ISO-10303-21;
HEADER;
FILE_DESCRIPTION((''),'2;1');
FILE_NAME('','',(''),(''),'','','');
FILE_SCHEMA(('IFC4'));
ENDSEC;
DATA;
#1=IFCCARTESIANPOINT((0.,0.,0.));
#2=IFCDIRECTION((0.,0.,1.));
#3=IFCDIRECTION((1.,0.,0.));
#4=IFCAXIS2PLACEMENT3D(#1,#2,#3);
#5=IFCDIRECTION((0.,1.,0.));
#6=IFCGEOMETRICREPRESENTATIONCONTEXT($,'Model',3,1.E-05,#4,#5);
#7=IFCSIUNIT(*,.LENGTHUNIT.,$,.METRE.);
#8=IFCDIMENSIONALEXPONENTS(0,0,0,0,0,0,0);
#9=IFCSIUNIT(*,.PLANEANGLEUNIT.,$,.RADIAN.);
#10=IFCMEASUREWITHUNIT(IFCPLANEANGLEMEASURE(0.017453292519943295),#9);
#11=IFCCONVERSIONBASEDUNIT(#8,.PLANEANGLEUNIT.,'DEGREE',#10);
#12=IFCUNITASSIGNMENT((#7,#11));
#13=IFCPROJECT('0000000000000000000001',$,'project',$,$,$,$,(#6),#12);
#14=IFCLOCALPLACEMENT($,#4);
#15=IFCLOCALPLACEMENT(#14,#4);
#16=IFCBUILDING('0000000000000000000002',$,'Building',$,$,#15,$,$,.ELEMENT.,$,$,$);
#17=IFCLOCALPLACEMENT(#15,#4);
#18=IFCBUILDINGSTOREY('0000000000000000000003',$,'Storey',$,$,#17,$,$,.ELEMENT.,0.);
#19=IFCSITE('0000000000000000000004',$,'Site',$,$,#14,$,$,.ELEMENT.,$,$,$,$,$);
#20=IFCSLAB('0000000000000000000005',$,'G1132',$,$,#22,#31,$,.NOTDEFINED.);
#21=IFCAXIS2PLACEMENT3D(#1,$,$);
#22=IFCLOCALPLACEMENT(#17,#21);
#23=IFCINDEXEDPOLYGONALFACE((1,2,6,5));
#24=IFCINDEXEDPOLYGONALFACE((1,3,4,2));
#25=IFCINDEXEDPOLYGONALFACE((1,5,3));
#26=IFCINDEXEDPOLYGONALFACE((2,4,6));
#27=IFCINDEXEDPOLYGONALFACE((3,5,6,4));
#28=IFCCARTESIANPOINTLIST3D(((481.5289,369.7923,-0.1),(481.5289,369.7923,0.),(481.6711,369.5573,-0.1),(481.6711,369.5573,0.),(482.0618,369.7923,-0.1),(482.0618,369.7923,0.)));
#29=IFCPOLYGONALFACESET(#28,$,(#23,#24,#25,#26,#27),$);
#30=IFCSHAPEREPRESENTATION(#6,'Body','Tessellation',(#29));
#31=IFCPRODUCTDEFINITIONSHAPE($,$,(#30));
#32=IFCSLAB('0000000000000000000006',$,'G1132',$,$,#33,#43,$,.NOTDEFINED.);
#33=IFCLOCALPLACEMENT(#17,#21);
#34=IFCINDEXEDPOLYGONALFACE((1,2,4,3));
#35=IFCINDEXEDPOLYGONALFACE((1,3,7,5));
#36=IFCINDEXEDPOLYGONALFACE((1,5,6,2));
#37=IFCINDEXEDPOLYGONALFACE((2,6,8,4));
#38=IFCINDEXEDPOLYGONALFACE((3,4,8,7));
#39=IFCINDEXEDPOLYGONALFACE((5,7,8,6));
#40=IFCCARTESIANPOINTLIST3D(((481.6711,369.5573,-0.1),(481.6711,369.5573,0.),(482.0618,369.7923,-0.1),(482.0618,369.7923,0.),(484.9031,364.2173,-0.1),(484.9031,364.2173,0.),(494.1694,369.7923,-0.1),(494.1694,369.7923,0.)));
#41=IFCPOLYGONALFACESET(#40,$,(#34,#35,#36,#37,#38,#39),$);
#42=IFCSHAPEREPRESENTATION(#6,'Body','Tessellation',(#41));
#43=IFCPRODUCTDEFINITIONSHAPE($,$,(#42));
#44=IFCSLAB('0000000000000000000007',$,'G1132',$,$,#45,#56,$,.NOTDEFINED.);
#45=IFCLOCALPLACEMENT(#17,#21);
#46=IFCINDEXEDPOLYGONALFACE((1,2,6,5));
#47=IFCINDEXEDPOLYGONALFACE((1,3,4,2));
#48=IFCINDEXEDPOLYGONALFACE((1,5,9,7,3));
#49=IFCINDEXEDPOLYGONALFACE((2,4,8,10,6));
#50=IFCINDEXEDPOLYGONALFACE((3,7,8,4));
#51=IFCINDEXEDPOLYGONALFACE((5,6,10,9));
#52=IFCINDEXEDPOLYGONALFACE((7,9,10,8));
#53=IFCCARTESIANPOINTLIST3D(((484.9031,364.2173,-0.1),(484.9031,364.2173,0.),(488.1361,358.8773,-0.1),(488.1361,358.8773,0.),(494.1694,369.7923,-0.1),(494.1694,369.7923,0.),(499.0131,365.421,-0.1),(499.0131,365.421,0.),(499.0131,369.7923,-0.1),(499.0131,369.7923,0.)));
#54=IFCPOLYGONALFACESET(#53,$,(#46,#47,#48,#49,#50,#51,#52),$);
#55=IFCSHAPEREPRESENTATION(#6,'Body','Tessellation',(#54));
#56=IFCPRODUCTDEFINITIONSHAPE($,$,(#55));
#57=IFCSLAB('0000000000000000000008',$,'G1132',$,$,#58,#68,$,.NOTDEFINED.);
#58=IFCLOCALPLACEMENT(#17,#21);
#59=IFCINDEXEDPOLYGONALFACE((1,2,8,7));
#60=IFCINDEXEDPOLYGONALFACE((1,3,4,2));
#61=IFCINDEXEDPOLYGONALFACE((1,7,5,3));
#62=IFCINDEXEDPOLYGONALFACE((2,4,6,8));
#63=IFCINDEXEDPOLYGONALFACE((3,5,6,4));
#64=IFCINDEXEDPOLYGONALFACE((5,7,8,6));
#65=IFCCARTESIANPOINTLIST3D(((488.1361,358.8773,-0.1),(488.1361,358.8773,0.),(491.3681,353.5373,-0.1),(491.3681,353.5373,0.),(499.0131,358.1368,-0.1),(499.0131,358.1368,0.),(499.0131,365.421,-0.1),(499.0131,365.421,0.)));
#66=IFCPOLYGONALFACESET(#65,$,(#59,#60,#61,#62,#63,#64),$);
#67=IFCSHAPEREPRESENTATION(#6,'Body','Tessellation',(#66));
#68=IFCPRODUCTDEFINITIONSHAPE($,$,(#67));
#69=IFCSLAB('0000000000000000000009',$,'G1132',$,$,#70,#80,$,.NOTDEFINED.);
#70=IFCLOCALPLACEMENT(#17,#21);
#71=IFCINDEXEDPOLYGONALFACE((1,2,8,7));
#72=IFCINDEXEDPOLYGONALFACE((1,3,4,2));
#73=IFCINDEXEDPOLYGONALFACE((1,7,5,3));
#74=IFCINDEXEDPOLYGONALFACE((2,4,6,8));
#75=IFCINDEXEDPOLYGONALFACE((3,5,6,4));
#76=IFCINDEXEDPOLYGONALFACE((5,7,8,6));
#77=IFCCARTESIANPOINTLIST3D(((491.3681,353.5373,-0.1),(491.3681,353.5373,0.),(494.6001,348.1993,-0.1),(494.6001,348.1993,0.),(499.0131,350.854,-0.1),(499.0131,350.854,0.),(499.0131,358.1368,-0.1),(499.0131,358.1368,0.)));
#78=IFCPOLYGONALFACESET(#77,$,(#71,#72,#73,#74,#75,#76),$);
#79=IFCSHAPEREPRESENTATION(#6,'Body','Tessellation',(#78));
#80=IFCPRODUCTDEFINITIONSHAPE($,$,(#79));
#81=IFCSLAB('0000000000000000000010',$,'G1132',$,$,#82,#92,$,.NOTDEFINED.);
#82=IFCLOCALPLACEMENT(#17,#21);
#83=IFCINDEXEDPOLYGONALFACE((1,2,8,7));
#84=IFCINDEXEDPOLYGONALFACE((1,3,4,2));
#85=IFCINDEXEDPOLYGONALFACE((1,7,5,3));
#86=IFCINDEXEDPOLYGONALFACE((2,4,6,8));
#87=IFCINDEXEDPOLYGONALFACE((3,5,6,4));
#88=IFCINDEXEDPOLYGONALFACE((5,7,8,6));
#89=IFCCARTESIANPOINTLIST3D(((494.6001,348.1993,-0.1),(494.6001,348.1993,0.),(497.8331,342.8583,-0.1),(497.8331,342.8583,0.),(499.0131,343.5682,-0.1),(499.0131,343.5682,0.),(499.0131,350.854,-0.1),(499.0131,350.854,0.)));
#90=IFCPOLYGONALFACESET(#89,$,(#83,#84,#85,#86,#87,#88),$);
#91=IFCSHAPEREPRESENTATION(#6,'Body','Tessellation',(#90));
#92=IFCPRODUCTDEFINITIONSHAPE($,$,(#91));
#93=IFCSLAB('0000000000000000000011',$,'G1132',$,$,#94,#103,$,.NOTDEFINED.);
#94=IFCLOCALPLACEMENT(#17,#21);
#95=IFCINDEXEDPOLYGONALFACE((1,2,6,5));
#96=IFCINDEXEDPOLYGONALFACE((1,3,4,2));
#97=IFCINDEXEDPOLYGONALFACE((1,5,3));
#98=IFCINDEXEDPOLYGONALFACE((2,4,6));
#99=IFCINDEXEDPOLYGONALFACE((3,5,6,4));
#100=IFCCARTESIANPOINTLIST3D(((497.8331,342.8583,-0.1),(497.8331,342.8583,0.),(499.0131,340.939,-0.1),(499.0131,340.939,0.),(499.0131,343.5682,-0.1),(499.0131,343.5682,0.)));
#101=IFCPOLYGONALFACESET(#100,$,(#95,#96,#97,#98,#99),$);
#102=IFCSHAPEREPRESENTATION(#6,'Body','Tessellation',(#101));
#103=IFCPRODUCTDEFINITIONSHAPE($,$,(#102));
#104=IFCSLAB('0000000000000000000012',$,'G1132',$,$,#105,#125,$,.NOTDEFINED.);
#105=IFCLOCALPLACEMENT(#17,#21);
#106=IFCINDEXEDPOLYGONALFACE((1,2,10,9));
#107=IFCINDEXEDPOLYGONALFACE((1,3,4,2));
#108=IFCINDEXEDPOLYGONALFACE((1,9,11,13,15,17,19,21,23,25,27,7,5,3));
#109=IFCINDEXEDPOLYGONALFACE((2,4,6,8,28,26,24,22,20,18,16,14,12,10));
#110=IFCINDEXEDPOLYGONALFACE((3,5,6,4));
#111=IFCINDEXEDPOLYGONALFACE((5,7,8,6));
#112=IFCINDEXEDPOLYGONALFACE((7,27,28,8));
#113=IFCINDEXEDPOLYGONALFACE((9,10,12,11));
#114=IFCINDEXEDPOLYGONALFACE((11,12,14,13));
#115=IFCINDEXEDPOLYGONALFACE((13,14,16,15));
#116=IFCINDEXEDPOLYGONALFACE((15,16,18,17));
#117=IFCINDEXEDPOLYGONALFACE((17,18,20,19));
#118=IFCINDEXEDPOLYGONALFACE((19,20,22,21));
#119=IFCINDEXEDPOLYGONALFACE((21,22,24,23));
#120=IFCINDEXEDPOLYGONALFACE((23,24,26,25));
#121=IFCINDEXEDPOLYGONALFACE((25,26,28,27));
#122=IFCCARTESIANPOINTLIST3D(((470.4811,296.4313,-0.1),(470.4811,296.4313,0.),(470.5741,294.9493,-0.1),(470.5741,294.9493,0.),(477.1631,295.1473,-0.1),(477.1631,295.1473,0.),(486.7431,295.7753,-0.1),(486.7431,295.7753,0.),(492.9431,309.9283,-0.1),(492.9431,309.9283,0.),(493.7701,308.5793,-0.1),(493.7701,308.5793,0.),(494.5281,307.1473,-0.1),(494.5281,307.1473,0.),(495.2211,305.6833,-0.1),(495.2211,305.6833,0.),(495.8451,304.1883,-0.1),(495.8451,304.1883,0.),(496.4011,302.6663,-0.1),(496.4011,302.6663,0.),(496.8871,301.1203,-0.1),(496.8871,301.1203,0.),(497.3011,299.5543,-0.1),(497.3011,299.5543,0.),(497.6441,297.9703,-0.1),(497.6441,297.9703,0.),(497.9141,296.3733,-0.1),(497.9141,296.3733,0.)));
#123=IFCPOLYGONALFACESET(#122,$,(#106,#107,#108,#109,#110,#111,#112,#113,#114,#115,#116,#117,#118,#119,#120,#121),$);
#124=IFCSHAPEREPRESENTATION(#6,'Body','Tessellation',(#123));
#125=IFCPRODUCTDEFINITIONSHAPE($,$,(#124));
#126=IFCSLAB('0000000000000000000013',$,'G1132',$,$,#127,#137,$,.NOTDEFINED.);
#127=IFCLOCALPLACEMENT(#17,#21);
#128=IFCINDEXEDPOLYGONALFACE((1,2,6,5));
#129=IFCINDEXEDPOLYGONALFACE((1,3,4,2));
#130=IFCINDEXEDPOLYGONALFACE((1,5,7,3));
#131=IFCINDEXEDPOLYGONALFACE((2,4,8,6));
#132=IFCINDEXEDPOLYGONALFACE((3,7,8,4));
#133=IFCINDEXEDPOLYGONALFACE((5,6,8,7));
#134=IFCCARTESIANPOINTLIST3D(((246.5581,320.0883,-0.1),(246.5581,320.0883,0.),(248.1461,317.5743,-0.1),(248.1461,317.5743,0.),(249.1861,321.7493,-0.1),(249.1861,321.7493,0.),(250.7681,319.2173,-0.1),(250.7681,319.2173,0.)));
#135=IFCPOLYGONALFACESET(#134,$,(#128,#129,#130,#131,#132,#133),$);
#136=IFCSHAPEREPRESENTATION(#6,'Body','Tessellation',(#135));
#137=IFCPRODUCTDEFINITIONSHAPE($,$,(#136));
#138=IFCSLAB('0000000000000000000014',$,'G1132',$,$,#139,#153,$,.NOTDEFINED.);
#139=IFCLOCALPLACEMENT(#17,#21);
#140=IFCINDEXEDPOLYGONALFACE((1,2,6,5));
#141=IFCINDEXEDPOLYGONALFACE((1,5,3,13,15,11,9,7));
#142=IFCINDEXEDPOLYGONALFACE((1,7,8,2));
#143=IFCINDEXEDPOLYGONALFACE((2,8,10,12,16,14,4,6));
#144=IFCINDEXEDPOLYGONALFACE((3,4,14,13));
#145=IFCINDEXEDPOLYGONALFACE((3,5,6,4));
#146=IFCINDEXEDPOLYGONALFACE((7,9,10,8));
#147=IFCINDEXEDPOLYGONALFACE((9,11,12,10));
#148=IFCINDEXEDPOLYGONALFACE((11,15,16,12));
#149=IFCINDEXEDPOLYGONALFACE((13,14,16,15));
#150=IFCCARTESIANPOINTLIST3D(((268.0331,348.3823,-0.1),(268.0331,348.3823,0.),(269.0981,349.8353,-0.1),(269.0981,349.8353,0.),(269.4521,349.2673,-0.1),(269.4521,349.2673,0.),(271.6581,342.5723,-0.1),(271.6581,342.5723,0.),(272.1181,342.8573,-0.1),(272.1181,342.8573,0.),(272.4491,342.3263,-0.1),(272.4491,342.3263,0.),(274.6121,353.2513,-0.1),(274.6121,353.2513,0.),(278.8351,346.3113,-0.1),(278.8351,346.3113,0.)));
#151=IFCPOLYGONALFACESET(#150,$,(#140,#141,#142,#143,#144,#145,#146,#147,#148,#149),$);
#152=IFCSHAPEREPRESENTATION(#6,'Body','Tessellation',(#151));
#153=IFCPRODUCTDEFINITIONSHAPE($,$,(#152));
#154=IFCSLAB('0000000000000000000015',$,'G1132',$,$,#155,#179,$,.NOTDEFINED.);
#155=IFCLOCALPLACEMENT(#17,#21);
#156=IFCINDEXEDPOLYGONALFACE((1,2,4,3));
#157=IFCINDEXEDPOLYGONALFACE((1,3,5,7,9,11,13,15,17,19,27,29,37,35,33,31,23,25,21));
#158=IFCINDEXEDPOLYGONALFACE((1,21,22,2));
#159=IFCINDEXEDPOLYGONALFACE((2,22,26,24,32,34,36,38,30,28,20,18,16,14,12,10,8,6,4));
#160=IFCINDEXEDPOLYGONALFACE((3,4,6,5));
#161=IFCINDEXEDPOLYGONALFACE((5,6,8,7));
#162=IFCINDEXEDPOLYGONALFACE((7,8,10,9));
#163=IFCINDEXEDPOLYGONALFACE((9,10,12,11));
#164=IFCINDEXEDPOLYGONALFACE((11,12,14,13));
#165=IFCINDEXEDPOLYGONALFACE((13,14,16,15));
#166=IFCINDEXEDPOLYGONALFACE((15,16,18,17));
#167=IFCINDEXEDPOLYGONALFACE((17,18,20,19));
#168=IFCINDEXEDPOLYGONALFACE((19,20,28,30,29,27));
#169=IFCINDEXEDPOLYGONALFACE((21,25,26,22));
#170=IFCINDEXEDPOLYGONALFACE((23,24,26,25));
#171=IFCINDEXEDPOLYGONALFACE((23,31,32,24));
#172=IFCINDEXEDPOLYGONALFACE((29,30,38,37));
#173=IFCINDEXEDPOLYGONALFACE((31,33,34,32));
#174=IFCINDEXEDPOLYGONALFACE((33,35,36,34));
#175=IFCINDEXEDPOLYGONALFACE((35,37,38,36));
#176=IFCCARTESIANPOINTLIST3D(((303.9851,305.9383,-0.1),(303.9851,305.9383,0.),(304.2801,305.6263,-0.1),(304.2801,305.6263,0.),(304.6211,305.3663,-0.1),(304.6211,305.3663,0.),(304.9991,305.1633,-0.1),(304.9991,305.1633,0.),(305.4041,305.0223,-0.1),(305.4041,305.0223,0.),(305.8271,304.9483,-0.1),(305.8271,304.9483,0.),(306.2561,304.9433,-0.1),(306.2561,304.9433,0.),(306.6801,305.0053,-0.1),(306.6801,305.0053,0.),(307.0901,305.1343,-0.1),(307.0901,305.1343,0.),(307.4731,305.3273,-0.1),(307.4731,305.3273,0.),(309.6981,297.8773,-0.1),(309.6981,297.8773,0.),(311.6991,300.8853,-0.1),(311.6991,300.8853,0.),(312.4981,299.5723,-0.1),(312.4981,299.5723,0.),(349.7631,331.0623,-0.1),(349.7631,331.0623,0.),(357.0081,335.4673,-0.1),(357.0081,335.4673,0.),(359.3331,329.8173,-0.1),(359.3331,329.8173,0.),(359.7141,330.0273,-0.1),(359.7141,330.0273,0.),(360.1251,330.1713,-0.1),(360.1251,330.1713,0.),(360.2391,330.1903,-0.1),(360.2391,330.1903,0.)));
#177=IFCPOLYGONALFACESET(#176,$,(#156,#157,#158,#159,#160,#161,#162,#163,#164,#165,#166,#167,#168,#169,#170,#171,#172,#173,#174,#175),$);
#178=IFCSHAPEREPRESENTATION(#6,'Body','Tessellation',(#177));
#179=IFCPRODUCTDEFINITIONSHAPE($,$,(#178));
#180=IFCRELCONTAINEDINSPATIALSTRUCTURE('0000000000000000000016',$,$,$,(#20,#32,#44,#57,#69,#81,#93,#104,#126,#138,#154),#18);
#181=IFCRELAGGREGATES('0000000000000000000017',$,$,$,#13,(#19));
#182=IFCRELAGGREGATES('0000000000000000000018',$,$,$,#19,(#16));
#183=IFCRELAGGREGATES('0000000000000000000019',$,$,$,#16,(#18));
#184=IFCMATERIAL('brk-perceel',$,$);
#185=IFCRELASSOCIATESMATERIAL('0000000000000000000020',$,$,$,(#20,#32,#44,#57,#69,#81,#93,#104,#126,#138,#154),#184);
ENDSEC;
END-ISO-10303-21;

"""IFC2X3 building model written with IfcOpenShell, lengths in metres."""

from ifc_helpers import new_model, entity, si_unit, converted_unit, direction, frame, origin_with_axes, place, context, project, spatial, polyline, outline, extrude, material, element, save


model = new_model("IFC2X3")

# Units and contexts
model_context = context("Model", 3, precision=1e-05, world=origin_with_axes(), true_north=direction((0.0, 1.0, 0.0)))
ifc_project = project(units=[si_unit("LENGTHUNIT", "METRE"), converted_unit("PLANEANGLEUNIT", "DEGREE", entity("IfcPlaneAngleMeasure", 0.017453292519943295), si_unit("PLANEANGLEUNIT", "RADIAN"), dimensions=[0, 0, 0, 0, 0, 0, 0])], contexts=[model_context])

# Site, building, storey
site_placement = place(None, origin_with_axes())
site = spatial("IfcSite", under=ifc_project, at=site_placement, Name="Site", CompositionType="ELEMENT")
building_placement = place(site_placement, origin_with_axes())
building = spatial("IfcBuilding", under=site, at=building_placement, Name="Building", CompositionType="ELEMENT")
storey_placement = place(building_placement, origin_with_axes())
storey = spatial("IfcBuildingStorey", under=building, at=storey_placement, Name="Storey", CompositionType="ELEMENT", Elevation=0.0)

# Slabs
ifc_material_1 = material(Name="brk-perceel")
slab_1_placement = place(storey_placement, frame((0.0, 0.0, -0.1), z_axis=(0.0, 0.0, 1.0), x_axis=(1.0, 0.0, 0.0)))
element("IfcSlab", 1, at=slab_1_placement, inside=storey, material=ifc_material_1, Name="G1132", PredefinedType="NOTDEFINED", context=model_context, shape_type="SweptSolid", body=[
    extrude(outline(polyline([(481.6711, 369.5573), (481.5289, 369.7923), (482.0618, 369.7923), (481.6711, 369.5573)])), origin_with_axes(), (0.0, 0.0, 1.0), 0.1),
])
slab_2_placement = place(storey_placement, frame((0.0, 0.0, -0.1), z_axis=(0.0, 0.0, 1.0), x_axis=(1.0, 0.0, 0.0)))
element("IfcSlab", 2, at=slab_2_placement, inside=storey, material=ifc_material_1, Name="G1132", PredefinedType="NOTDEFINED", context=model_context, shape_type="SweptSolid", body=[
    extrude(outline(polyline([(484.9031, 364.2173), (481.6711, 369.5573), (482.0618, 369.7923), (494.1694, 369.7923), (484.9031, 364.2173)])), origin_with_axes(), (0.0, 0.0, 1.0), 0.1),
])
slab_3_placement = place(storey_placement, frame((0.0, 0.0, -0.1), z_axis=(0.0, 0.0, 1.0), x_axis=(1.0, 0.0, 0.0)))
element("IfcSlab", 3, at=slab_3_placement, inside=storey, material=ifc_material_1, Name="G1132", PredefinedType="NOTDEFINED", context=model_context, shape_type="SweptSolid", body=[
    extrude(outline(polyline([(488.1361, 358.8773), (484.9031, 364.2173), (494.1694, 369.7923), (499.0131, 369.7923), (499.0131, 365.421), (488.1361, 358.8773)])), origin_with_axes(), (0.0, 0.0, 1.0), 0.1),
])
slab_4_placement = place(storey_placement, frame((0.0, 0.0, -0.1), z_axis=(0.0, 0.0, 1.0), x_axis=(1.0, 0.0, 0.0)))
element("IfcSlab", 4, at=slab_4_placement, inside=storey, material=ifc_material_1, Name="G1132", PredefinedType="NOTDEFINED", context=model_context, shape_type="SweptSolid", body=[
    extrude(outline(polyline([(491.3681, 353.5373), (488.1361, 358.8773), (499.0131, 365.421), (499.0131, 358.1368), (491.3681, 353.5373)])), origin_with_axes(), (0.0, 0.0, 1.0), 0.1),
])
slab_5_placement = place(storey_placement, frame((0.0, 0.0, -0.1), z_axis=(0.0, 0.0, 1.0), x_axis=(1.0, 0.0, 0.0)))
element("IfcSlab", 5, at=slab_5_placement, inside=storey, material=ifc_material_1, Name="G1132", PredefinedType="NOTDEFINED", context=model_context, shape_type="SweptSolid", body=[
    extrude(outline(polyline([(494.6001, 348.1993), (491.3681, 353.5373), (499.0131, 358.1368), (499.0131, 350.854), (494.6001, 348.1993)])), origin_with_axes(), (0.0, 0.0, 1.0), 0.1),
])
slab_6_placement = place(storey_placement, frame((0.0, 0.0, -0.1), z_axis=(0.0, 0.0, 1.0), x_axis=(1.0, 0.0, 0.0)))
element("IfcSlab", 6, at=slab_6_placement, inside=storey, material=ifc_material_1, Name="G1132", PredefinedType="NOTDEFINED", context=model_context, shape_type="SweptSolid", body=[
    extrude(outline(polyline([(497.8331, 342.8583), (494.6001, 348.1993), (499.0131, 350.854), (499.0131, 343.5682), (497.8331, 342.8583)])), origin_with_axes(), (0.0, 0.0, 1.0), 0.1),
])
slab_7_placement = place(storey_placement, frame((0.0, 0.0, -0.1), z_axis=(0.0, 0.0, 1.0), x_axis=(1.0, 0.0, 0.0)))
element("IfcSlab", 7, at=slab_7_placement, inside=storey, material=ifc_material_1, Name="G1132", PredefinedType="NOTDEFINED", context=model_context, shape_type="SweptSolid", body=[
    extrude(outline(polyline([(497.8331, 342.8583), (499.0131, 343.5682), (499.0131, 340.939), (497.8331, 342.8583)])), origin_with_axes(), (0.0, 0.0, 1.0), 0.1),
])
slab_8_placement = place(storey_placement, frame((0.0, 0.0, -0.1), z_axis=(0.0, 0.0, 1.0), x_axis=(1.0, 0.0, 0.0)))
element("IfcSlab", 8, at=slab_8_placement, inside=storey, material=ifc_material_1, Name="G1132", PredefinedType="NOTDEFINED", context=model_context, shape_type="SweptSolid", body=[
    extrude(outline(polyline([(494.5281, 307.1473), (495.2211, 305.6833), (495.8451, 304.1883), (496.4011, 302.6663), (496.8871, 301.1203), (497.3011, 299.5543), (497.6441, 297.9703), (497.9141, 296.3733), (486.7431, 295.7753), (477.1631, 295.1473), (470.5741, 294.9493), (470.4811, 296.4313), (492.9431, 309.9283), (493.7701, 308.5793), (494.5281, 307.1473)])), origin_with_axes(), (0.0, 0.0, 1.0), 0.1),
])
slab_9_placement = place(storey_placement, frame((0.0, 0.0, -0.1), z_axis=(0.0, 0.0, 1.0), x_axis=(1.0, 0.0, 0.0)))
element("IfcSlab", 9, at=slab_9_placement, inside=storey, material=ifc_material_1, Name="G1132", PredefinedType="NOTDEFINED", context=model_context, shape_type="SweptSolid", body=[
    extrude(outline(polyline([(249.1861, 321.7493), (250.7681, 319.2173), (248.1461, 317.5743), (246.5581, 320.0883), (249.1861, 321.7493)])), origin_with_axes(), (0.0, 0.0, 1.0), 0.1),
])
slab_10_placement = place(storey_placement, frame((0.0, 0.0, -0.1), z_axis=(0.0, 0.0, 1.0), x_axis=(1.0, 0.0, 0.0)))
element("IfcSlab", 10, at=slab_10_placement, inside=storey, material=ifc_material_1, Name="G1132", PredefinedType="NOTDEFINED", context=model_context, shape_type="SweptSolid", body=[
    extrude(outline(polyline([(272.1181, 342.8573), (271.6581, 342.5723), (268.0331, 348.3823), (269.4521, 349.2673), (269.0981, 349.8353), (274.6121, 353.2513), (278.8351, 346.3113), (272.4491, 342.3263), (272.1181, 342.8573)])), origin_with_axes(), (0.0, 0.0, 1.0), 0.1),
])
slab_11_placement = place(storey_placement, frame((0.0, 0.0, -0.1), z_axis=(0.0, 0.0, 1.0), x_axis=(1.0, 0.0, 0.0)))
element("IfcSlab", 11, at=slab_11_placement, inside=storey, material=ifc_material_1, Name="G1132", PredefinedType="NOTDEFINED", context=model_context, shape_type="SweptSolid", body=[
    extrude(outline(polyline([(360.1251, 330.1713), (359.7141, 330.0273), (359.3331, 329.8173), (311.6991, 300.8853), (312.4981, 299.5723), (309.6981, 297.8773), (303.9851, 305.9383), (304.2801, 305.6263), (304.6211, 305.3663), (304.9991, 305.1633), (305.4041, 305.0223), (305.8271, 304.9483), (306.2561, 304.9433), (306.6801, 305.0053), (307.0901, 305.1343), (307.4731, 305.3273), (349.7631, 331.0623), (357.0081, 335.4673), (360.2391, 330.1903), (360.1251, 330.1713)])), origin_with_axes(), (0.0, 0.0, 1.0), 0.1),
])

save(model, "model.ifc")
